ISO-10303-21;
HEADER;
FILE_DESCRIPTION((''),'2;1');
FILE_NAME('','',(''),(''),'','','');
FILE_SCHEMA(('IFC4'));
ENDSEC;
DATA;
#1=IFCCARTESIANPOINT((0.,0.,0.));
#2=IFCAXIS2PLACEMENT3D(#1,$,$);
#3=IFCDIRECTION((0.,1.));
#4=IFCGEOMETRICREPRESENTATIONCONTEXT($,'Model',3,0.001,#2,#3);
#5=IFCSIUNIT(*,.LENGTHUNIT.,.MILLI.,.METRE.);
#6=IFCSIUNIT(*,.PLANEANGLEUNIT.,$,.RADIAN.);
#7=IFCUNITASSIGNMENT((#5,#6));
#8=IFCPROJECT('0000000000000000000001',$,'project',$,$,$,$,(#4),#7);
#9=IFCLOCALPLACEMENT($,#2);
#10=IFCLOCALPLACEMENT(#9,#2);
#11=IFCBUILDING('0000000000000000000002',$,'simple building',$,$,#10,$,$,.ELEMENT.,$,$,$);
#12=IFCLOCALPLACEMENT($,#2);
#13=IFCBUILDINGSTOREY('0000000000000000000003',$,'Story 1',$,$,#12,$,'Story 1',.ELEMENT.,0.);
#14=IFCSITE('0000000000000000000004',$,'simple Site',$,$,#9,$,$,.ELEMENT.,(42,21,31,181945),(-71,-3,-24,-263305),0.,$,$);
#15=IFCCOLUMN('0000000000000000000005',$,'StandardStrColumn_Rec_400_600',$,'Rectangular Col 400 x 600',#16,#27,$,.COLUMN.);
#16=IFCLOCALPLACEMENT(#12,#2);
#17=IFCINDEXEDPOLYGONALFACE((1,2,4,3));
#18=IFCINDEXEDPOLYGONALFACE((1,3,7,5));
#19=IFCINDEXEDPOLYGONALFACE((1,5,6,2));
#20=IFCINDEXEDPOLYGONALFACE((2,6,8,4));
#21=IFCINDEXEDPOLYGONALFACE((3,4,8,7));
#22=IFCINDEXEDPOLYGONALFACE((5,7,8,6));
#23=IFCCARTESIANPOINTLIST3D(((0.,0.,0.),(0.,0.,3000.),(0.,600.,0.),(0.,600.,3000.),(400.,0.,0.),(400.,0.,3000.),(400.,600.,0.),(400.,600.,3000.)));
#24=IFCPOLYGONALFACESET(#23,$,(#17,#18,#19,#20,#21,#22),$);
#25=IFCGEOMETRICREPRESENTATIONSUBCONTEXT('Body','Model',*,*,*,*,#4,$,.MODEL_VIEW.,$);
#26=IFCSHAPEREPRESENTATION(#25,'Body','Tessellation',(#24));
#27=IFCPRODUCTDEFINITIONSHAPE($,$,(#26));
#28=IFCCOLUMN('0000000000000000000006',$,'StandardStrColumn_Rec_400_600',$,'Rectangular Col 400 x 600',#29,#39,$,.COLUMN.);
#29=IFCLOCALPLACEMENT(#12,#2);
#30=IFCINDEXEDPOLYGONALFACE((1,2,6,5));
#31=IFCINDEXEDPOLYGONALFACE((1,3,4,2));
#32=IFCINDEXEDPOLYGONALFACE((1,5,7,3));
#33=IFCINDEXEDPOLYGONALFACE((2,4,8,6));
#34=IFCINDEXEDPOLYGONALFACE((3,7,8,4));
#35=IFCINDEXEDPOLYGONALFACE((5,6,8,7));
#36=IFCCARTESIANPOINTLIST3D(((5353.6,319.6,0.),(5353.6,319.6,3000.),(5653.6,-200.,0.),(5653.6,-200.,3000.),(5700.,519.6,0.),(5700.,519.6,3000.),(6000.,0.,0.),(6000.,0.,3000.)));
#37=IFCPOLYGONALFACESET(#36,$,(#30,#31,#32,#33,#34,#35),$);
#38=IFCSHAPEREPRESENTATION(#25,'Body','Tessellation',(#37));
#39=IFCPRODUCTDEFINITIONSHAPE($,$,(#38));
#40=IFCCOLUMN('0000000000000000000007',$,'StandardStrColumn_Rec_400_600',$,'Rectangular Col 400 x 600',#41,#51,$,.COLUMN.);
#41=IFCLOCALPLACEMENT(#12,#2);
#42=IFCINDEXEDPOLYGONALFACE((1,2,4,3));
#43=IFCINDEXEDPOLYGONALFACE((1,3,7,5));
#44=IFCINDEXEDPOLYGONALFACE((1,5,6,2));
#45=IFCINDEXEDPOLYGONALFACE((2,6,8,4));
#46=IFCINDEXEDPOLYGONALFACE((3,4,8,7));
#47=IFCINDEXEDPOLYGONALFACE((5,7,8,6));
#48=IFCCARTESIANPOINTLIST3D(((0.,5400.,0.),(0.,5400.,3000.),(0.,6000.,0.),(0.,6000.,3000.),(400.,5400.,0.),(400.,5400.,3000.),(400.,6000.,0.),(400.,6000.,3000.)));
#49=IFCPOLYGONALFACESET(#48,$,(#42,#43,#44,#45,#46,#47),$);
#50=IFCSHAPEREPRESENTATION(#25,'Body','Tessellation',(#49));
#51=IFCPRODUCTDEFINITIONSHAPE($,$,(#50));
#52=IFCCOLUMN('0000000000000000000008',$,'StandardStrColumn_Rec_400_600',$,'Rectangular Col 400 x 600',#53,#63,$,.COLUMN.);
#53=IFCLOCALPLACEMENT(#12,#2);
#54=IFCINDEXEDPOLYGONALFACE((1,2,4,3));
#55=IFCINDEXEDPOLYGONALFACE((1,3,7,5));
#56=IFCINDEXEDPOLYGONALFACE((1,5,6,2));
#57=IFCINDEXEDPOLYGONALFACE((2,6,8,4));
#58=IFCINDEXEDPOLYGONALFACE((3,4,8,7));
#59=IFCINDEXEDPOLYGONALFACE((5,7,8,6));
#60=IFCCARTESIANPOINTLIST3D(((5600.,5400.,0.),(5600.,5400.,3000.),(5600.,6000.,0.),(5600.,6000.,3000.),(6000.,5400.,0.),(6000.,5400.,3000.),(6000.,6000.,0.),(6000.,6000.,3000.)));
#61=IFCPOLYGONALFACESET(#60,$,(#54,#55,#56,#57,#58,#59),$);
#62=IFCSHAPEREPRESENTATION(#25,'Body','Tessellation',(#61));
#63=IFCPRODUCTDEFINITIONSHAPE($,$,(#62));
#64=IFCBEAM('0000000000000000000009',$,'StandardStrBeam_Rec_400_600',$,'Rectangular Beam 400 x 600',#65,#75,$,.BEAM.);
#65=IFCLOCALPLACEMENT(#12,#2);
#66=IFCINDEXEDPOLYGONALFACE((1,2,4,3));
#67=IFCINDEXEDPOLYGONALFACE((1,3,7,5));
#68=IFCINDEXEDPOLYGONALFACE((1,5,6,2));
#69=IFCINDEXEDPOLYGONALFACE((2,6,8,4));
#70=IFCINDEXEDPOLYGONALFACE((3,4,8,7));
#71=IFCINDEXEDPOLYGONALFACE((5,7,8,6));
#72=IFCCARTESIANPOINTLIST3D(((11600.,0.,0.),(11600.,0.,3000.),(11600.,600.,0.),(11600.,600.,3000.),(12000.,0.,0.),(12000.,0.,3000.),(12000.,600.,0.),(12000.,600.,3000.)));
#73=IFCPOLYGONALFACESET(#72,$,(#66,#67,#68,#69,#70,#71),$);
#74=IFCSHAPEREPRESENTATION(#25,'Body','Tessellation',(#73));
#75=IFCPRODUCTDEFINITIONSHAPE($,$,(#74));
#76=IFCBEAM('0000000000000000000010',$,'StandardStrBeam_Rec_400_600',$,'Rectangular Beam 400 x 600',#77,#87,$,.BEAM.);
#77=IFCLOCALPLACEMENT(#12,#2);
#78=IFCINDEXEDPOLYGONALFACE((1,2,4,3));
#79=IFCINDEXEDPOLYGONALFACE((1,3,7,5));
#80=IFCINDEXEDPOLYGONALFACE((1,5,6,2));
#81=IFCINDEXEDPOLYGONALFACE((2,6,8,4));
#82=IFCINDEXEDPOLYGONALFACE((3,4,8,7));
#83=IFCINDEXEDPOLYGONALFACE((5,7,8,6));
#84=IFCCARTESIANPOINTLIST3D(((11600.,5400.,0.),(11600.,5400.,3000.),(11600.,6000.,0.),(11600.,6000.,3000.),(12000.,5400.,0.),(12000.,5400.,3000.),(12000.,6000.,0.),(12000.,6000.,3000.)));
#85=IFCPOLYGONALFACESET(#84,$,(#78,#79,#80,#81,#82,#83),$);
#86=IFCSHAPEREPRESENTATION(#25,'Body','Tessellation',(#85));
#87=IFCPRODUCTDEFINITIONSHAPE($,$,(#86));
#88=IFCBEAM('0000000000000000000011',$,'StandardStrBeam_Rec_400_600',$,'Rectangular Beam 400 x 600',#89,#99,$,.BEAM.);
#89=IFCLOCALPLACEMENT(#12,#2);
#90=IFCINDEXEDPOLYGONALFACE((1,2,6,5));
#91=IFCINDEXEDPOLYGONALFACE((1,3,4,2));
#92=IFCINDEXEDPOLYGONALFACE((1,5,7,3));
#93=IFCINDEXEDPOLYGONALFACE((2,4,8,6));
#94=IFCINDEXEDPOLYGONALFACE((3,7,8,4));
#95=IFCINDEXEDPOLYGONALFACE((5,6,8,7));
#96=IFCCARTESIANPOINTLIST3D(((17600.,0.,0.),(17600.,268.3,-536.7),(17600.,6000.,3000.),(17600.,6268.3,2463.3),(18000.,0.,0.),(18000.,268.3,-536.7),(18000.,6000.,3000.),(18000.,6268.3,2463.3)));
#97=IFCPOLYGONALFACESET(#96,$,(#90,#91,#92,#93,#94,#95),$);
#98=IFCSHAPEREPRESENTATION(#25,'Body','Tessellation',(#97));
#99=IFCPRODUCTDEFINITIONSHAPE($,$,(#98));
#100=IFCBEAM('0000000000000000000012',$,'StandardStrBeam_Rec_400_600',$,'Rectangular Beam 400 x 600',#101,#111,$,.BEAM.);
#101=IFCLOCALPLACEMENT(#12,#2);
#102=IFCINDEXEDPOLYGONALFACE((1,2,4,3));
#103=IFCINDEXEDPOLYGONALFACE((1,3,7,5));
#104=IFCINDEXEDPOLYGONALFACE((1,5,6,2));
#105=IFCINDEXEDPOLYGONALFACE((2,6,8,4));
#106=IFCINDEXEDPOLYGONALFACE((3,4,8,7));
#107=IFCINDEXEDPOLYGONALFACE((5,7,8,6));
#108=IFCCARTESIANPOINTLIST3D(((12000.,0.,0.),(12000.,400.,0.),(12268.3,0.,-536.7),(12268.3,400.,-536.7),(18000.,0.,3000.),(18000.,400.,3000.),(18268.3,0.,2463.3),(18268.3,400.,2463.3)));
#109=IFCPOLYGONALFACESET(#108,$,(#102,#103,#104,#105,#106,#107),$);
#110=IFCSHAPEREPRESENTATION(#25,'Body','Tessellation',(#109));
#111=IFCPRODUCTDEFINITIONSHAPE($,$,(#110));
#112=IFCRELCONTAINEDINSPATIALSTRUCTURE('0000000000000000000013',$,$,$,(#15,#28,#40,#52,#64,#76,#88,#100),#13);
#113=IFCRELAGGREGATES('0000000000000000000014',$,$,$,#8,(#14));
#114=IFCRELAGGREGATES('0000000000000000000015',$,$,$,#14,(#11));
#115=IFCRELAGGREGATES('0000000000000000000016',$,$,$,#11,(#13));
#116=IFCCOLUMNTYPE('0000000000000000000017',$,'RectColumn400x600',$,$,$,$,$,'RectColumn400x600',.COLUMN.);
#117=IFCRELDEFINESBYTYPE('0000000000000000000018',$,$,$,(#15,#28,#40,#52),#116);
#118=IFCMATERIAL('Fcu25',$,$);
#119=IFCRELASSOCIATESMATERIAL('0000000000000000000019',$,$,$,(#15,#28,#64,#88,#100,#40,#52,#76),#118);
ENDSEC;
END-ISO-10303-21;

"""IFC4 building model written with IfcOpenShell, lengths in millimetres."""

from ifc_helpers import new_model, si_unit, direction, frame, origin, origin_with_axes, origin_2d_with_axis, place, context, subcontext, project, spatial, rectangle, extrude, material, material_profile, profile_set, profile_usage, type_object, element, save


model = new_model("IFC4")

# Units and contexts
model_context = context("Model", 3, precision=0.001, world=origin(), true_north=direction((0.0, 1.0)))
body_context = subcontext(model_context, "Body", "Model", "MODEL_VIEW")
ifc_project = project(units=[si_unit("LENGTHUNIT", "METRE", prefix="MILLI"), si_unit("PLANEANGLEUNIT", "RADIAN")], contexts=[model_context])

# Site, building, storey
site_placement = place(None, origin())
site = spatial("IfcSite", under=ifc_project, at=site_placement, Name="simple Site", CompositionType="ELEMENT", RefLatitude=(42, 21, 31, 181945), RefLongitude=(-71, -3, -24, -263305), RefElevation=0.0)
building_placement = place(site_placement, origin())
building = spatial("IfcBuilding", under=site, at=building_placement, Name="simple building", CompositionType="ELEMENT")
storey_placement = place(None, origin())
storey = spatial("IfcBuildingStorey", under=building, at=storey_placement, Name="Story 1", LongName="Story 1", CompositionType="ELEMENT", Elevation=0.0)

# Columns
ifc_material = material(Name="Fcu25")
ifc_material_profile = material_profile(ifc_material, rectangle(XDim=400.0, YDim=600.0, at=origin_2d_with_axis()))
ifc_profile_set = profile_set([ifc_material_profile])
ifc_profile_usage_1 = profile_usage(ifc_profile_set, cardinal=7)
column_type = type_object("IfcColumnType", Name="RectColumn400x600", ElementType="RectColumn400x600", PredefinedType="COLUMN")
column_1_placement = place(None, frame((200.0, 300.0, 0.0), z_axis=(0.0, 0.0, 1.0), x_axis=(1.0, 0.0, 0.0)))
element("IfcColumn", 1, at=column_1_placement, inside=storey, type_object=column_type, material=ifc_profile_usage_1, Name="StandardStrColumn_Rec_400_600", ObjectType="Rectangular Col 400 x 600", PredefinedType="COLUMN", context=body_context, shape_type="SweptSolid", body=[
    extrude(rectangle(XDim=400.0, YDim=600.0, at=origin_2d_with_axis()), origin_with_axes(), (0.0, 0.0, 1.0), 3000.0),
])
ifc_profile_usage_2 = profile_usage(ifc_profile_set, cardinal=9)
column_2_placement = place(None, frame((5676.8, 159.8, 0.0), z_axis=(0.0, 0.0, 1.0), x_axis=(0.866025, 0.5, 0.0)))
element("IfcColumn", 2, at=column_2_placement, inside=storey, type_object=column_type, material=ifc_profile_usage_2, Name="StandardStrColumn_Rec_400_600", ObjectType="Rectangular Col 400 x 600", PredefinedType="COLUMN", context=body_context, shape_type="SweptSolid", body=[
    extrude(rectangle(XDim=400.0, YDim=600.0, at=origin_2d_with_axis()), origin_with_axes(), (0.0, 0.0, 1.0), 3000.0),
])
ifc_profile_usage_3 = profile_usage(ifc_profile_set, cardinal=1)
column_3_placement = place(None, frame((200.0, 5700.0, 0.0), z_axis=(0.0, 0.0, 1.0), x_axis=(1.0, 0.0, 0.0)))
element("IfcColumn", 3, at=column_3_placement, inside=storey, type_object=column_type, material=ifc_profile_usage_3, Name="StandardStrColumn_Rec_400_600", ObjectType="Rectangular Col 400 x 600", PredefinedType="COLUMN", context=body_context, shape_type="SweptSolid", body=[
    extrude(rectangle(XDim=400.0, YDim=600.0, at=origin_2d_with_axis()), origin_with_axes(), (0.0, 0.0, 1.0), 3000.0),
])
ifc_profile_usage_4 = profile_usage(ifc_profile_set, cardinal=3)
column_4_placement = place(None, frame((5800.0, 5700.0, 0.0), z_axis=(0.0, 0.0, 1.0), x_axis=(1.0, 0.0, 0.0)))
element("IfcColumn", 4, at=column_4_placement, inside=storey, type_object=column_type, material=ifc_profile_usage_4, Name="StandardStrColumn_Rec_400_600", ObjectType="Rectangular Col 400 x 600", PredefinedType="COLUMN", context=body_context, shape_type="SweptSolid", body=[
    extrude(rectangle(XDim=400.0, YDim=600.0, at=origin_2d_with_axis()), origin_with_axes(), (0.0, 0.0, 1.0), 3000.0),
])

# Beams
beam_1_placement = place(None, frame((11800.0, 300.0, 0.0), z_axis=(0.0, 0.0, 1.0), x_axis=(1.0, 0.0, 0.0)))
element("IfcBeam", 5, at=beam_1_placement, inside=storey, material=ifc_profile_usage_2, Name="StandardStrBeam_Rec_400_600", ObjectType="Rectangular Beam 400 x 600", PredefinedType="BEAM", context=body_context, shape_type="SweptSolid", body=[
    extrude(rectangle(XDim=400.0, YDim=600.0, at=origin_2d_with_axis()), origin_with_axes(), (0.0, 0.0, 1.0), 3000.0),
])
beam_2_placement = place(None, frame((11800.0, 5700.0, 0.0), z_axis=(0.0, 0.0, 1.0), x_axis=(1.0, 0.0, 0.0)))
element("IfcBeam", 6, at=beam_2_placement, inside=storey, material=ifc_profile_usage_4, Name="StandardStrBeam_Rec_400_600", ObjectType="Rectangular Beam 400 x 600", PredefinedType="BEAM", context=body_context, shape_type="SweptSolid", body=[
    extrude(rectangle(XDim=400.0, YDim=600.0, at=origin_2d_with_axis()), origin_with_axes(), (0.0, 0.0, 1.0), 3000.0),
])
for number, where, z_axis, x_axis, name in (
    (7, (17800.0, 134.2, -268.3), (0.0, 0.894427, 0.447214), (1.0, 0.0, 0.0), "StandardStrBeam_Rec_400_600"),
    (8, (12134.2, 200.0, -268.3), (0.894427, 0.0, 0.447214), (0.0, -1.0, 0.0), "StandardStrBeam_Rec_400_600"),
):
    element("IfcBeam", number, at=place(None, frame(where, z_axis=z_axis, x_axis=x_axis)), inside=storey, material=ifc_profile_usage_2, Name=name, ObjectType="Rectangular Beam 400 x 600", PredefinedType="BEAM", context=body_context, shape_type="SweptSolid", body=[
        extrude(rectangle(XDim=400.0, YDim=600.0, at=origin_2d_with_axis()), origin_with_axes(), (0.0, 0.0, 1.0), 6708.2),
    ])

save(model, "model.ifc")
